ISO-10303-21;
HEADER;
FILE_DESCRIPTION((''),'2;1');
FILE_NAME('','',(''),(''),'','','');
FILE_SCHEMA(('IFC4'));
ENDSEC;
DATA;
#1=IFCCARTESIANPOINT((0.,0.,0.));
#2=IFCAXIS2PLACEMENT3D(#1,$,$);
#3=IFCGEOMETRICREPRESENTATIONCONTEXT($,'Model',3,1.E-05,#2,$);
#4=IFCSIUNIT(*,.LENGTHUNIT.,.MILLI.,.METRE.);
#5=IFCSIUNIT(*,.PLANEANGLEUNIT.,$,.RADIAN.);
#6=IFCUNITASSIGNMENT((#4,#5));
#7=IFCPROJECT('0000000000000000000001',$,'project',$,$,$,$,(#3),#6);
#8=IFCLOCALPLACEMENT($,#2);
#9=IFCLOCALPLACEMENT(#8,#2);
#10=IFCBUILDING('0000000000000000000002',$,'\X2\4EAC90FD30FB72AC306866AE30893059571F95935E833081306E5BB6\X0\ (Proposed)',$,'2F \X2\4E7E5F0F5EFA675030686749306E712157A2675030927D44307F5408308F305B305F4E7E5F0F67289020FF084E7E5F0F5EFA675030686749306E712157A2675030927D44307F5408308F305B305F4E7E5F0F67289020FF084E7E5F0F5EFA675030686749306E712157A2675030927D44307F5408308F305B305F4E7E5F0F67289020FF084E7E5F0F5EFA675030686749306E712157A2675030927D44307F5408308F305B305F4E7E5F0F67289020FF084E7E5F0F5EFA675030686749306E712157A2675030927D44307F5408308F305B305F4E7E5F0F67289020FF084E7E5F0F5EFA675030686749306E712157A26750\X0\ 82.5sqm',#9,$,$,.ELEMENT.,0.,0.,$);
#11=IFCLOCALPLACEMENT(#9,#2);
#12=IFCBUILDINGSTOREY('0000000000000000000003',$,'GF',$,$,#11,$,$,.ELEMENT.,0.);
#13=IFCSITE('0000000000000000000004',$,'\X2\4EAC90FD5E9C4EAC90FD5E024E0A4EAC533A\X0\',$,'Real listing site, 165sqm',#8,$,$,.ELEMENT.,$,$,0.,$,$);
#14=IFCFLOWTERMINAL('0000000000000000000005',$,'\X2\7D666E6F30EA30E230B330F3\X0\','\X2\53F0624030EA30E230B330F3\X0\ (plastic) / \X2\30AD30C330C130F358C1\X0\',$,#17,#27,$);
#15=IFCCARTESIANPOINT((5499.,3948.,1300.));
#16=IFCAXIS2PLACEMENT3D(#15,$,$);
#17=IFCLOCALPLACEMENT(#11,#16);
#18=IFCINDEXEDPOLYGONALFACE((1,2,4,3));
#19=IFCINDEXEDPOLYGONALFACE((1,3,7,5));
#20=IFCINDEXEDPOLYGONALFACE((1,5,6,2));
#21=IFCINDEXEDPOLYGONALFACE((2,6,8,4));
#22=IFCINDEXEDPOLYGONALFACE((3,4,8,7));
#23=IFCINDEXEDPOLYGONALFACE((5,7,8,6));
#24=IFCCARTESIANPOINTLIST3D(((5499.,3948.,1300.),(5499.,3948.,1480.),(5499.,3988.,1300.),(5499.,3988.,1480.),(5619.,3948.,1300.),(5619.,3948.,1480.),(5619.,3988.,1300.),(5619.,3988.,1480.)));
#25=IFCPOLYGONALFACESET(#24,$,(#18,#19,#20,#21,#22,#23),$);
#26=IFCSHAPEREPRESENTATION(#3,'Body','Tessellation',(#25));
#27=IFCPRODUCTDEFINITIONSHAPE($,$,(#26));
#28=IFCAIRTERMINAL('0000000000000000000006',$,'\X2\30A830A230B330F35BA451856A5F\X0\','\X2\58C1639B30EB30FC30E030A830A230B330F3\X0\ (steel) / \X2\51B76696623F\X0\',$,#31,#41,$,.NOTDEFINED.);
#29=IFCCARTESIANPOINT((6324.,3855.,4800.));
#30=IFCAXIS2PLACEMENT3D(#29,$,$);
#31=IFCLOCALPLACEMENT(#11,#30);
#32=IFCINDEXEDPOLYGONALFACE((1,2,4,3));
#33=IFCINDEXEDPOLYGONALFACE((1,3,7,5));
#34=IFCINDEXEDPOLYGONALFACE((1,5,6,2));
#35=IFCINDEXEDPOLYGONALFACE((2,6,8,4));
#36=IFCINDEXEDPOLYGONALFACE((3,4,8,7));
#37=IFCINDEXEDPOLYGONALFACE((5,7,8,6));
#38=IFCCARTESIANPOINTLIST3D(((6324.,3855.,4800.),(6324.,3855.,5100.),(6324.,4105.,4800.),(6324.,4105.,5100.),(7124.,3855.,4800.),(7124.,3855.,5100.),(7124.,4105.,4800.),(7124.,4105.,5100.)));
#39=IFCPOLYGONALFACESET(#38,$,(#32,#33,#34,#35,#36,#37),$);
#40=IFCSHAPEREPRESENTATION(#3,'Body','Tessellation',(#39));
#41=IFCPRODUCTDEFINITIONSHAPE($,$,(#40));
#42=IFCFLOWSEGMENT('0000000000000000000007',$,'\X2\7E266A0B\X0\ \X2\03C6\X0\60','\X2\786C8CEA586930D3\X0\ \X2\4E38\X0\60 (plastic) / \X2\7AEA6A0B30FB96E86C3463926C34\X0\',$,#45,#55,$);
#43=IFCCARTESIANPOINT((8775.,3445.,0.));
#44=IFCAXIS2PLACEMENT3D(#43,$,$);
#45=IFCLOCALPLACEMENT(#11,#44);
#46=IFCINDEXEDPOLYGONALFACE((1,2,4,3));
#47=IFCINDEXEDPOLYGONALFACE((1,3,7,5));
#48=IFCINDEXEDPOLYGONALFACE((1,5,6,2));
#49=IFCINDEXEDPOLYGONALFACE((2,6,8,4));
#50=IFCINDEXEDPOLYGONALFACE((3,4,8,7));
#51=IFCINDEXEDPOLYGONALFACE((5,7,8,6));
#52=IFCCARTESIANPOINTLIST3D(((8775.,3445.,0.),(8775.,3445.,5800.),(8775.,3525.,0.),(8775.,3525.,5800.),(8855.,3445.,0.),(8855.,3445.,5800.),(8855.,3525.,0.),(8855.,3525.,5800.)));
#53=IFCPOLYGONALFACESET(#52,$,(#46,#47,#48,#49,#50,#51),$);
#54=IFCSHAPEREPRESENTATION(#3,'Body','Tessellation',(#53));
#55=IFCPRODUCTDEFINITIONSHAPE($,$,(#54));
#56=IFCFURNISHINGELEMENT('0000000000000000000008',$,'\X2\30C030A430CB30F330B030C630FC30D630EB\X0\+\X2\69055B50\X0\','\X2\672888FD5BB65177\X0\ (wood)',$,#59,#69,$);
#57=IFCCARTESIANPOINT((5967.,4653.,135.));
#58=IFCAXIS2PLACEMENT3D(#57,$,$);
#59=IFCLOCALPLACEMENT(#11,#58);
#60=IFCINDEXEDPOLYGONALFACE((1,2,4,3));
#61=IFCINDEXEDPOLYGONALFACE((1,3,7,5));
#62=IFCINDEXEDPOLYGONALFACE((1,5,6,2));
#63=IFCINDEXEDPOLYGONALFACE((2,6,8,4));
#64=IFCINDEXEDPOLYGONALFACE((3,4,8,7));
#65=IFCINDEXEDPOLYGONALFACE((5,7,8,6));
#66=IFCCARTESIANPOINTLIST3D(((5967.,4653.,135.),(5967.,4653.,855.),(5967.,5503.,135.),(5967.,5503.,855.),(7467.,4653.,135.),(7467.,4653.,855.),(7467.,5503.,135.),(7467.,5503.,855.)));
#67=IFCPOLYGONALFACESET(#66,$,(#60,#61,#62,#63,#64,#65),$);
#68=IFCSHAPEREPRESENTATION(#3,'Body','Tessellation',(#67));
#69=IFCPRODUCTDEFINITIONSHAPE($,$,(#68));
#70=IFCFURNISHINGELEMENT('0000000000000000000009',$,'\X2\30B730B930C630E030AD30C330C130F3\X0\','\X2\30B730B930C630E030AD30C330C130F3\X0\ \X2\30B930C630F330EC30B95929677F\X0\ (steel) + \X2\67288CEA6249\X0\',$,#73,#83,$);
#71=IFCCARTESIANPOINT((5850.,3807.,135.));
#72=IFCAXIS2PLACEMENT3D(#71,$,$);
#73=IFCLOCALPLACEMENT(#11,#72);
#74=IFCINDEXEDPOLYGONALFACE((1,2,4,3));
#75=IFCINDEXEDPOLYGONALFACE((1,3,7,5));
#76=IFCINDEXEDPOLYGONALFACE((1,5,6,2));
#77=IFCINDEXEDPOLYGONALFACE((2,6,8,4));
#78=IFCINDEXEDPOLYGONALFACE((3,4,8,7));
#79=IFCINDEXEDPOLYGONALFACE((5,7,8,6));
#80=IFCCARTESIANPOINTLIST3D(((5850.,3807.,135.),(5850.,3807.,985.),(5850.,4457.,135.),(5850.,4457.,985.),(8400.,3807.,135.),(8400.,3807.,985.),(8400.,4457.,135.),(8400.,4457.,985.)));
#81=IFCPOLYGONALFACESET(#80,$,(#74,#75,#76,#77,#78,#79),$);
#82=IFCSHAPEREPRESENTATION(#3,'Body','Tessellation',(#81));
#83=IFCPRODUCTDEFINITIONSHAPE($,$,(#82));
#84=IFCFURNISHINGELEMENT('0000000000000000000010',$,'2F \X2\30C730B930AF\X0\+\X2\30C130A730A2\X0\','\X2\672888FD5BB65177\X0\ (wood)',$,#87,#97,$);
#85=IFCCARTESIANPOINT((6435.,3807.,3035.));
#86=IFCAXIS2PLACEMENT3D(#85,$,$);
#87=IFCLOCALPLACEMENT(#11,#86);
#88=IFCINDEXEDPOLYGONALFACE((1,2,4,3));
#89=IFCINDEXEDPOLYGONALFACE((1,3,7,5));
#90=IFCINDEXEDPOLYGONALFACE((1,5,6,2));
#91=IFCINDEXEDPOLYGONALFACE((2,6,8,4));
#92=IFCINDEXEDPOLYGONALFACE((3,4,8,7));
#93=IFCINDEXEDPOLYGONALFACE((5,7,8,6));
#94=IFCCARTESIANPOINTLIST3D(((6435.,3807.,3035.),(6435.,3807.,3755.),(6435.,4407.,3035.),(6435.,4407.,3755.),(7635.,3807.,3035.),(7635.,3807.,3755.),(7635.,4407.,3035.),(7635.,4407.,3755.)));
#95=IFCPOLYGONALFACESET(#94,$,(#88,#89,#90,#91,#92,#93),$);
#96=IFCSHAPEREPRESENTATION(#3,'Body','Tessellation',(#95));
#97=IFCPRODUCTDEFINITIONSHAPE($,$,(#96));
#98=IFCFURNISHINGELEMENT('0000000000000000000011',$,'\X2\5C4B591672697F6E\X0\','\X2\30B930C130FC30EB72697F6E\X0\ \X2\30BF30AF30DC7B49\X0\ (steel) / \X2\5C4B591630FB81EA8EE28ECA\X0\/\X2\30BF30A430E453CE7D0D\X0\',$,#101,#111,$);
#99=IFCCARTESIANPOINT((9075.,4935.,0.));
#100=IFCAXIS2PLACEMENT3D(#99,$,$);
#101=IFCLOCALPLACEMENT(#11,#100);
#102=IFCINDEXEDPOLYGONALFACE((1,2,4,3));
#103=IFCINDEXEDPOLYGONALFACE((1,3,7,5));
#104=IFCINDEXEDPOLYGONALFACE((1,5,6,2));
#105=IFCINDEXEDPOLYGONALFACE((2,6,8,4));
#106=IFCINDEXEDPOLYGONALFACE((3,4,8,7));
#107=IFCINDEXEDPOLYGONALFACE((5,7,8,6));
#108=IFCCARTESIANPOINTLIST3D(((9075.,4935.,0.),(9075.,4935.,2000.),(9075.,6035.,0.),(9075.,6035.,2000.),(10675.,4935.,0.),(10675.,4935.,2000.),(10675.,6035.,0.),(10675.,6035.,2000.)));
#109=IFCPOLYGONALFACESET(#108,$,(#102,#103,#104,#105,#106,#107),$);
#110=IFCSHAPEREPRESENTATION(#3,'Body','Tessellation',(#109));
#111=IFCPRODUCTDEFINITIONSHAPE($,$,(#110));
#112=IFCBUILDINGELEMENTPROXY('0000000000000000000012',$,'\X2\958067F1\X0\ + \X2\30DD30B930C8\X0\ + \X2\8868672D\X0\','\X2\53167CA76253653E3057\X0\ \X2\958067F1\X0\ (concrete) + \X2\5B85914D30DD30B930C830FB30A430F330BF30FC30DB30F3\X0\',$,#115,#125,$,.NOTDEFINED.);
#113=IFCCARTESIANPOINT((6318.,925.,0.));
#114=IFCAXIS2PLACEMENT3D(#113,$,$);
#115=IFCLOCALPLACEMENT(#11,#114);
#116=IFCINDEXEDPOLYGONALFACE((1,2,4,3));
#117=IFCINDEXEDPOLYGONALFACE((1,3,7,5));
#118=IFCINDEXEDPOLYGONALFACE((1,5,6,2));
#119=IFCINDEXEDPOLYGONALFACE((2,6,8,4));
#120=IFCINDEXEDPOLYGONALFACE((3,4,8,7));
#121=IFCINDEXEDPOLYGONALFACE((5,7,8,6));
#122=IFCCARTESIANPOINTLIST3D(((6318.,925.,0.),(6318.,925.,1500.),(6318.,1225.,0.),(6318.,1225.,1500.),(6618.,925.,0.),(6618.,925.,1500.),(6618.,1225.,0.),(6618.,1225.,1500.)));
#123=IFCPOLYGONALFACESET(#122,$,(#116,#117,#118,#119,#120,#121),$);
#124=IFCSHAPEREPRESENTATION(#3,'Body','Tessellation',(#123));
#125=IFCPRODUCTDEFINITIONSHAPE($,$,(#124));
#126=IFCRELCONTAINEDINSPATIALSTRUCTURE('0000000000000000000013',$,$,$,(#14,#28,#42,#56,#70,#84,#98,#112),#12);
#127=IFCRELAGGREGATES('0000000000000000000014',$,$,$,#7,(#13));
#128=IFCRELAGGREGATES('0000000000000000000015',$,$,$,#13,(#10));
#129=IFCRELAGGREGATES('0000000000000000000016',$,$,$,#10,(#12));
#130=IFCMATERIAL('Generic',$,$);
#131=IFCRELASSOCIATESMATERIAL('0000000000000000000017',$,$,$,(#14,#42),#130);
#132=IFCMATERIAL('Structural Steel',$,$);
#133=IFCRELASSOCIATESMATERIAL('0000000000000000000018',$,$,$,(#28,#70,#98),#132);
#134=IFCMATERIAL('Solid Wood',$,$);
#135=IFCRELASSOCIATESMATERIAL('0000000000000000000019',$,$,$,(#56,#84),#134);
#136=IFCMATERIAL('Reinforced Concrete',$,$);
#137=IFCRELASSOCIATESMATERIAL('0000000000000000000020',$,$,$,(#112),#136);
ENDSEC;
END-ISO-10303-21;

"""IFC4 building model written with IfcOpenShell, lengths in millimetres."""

from ifc_helpers import new_model, si_unit, frame, frame_2d, origin, place, context, project, spatial, rectangle, extrude, material, element, save


model = new_model("IFC4")

# Units and contexts
model_context = context("Model", 3, precision=1e-05, world=origin())
ifc_project = project(units=[si_unit("LENGTHUNIT", "METRE", prefix="MILLI"), si_unit("PLANEANGLEUNIT", "RADIAN")], contexts=[model_context])

# Site, building, storey
site_placement = place(None, origin())
site = spatial("IfcSite", under=ifc_project, at=site_placement, Name="京都府京都市上京区", ObjectType="Real listing site, 165sqm", CompositionType="ELEMENT", RefElevation=0.0)
building_placement = place(site_placement, origin())
building = spatial("IfcBuilding", under=site, at=building_placement, Name="京都・犬と暮らす土間広めの家 (Proposed)", ObjectType="2F 乾式建材と杉の無垢材を組み合わせた乾式木造（乾式建材と杉の無垢材を組み合わせた乾式木造（乾式建材と杉の無垢材を組み合わせた乾式木造（乾式建材と杉の無垢材を組み合わせた乾式木造（乾式建材と杉の無垢材を組み合わせた乾式木造（乾式建材と杉の無垢材 82.5sqm", CompositionType="ELEMENT", ElevationOfRefHeight=0.0, ElevationOfTerrain=0.0)
storey_placement = place(building_placement, origin())
storey = spatial("IfcBuildingStorey", under=building, at=storey_placement, Name="GF", CompositionType="ELEMENT", Elevation=0.0)

# Shared definitions
ifc_material_1 = material(Name="Solid Wood")

# Shared definitions
ifc_material_2 = material(Name="Reinforced Concrete")

# Shared definitions
ifc_material_3 = material(Name="Structural Steel")

# Flow terminal
ifc_material_4 = material(Name="Generic")
flow_terminal_1_placement = place(storey_placement, frame((5499.0, 3948.0, 1300.0)))
element("IfcFlowTerminal", 1, at=flow_terminal_1_placement, inside=storey, material=ifc_material_4, Name="給湯リモコン", Description="台所リモコン (plastic) / キッチン壁", context=model_context, shape_type="SweptSolid", body=[
    extrude(rectangle(XDim=120.0, YDim=40.0, at=frame_2d((60.0, 20.0))), frame((5499.0, 3948.0, 1300.0)), (0.0, 0.0, 1.0), 180.0),
])

# Air terminal
air_terminal_placement = place(storey_placement, frame((6324.0, 3855.0, 4800.0)))
element("IfcAirTerminal", 2, at=air_terminal_placement, inside=storey, material=ifc_material_3, Name="エアコン室内機", Description="壁掛ルームエアコン (steel) / 冷暖房", PredefinedType="NOTDEFINED", context=model_context, shape_type="SweptSolid", body=[
    extrude(rectangle(XDim=800.0, YDim=250.0, at=frame_2d((400.0, 125.0))), frame((6324.0, 3855.0, 4800.0)), (0.0, 0.0, 1.0), 300.0),
])

# Flow segment
flow_segment_placement = place(storey_placement, frame((8775.0, 3445.0, 0.0)))
element("IfcFlowSegment", 3, at=flow_segment_placement, inside=storey, material=ifc_material_4, Name="縦樋 φ60", Description="硬質塩ビ 丸60 (plastic) / 竪樋・雨水排水", context=model_context, shape_type="SweptSolid", body=[
    extrude(rectangle(XDim=80.0, YDim=80.0, at=frame_2d((40.0, 40.0))), frame((8775.0, 3445.0, 0.0)), (0.0, 0.0, 1.0), 5800.0),
])

# Furnishing elements
furnishing_1_placement = place(storey_placement, frame((5967.0, 4653.0, 135.0)))
element("IfcFurnishingElement", 4, at=furnishing_1_placement, inside=storey, material=ifc_material_1, Name="ダイニングテーブル+椅子", Description="木製家具 (wood)", context=model_context, shape_type="SweptSolid", body=[
    extrude(rectangle(XDim=1500.0, YDim=850.0, at=frame_2d((750.0, 425.0))), frame((5967.0, 4653.0, 135.0)), (0.0, 0.0, 1.0), 720.0),
])
furnishing_2_placement = place(storey_placement, frame((5850.0, 3807.0, 135.0)))
element("IfcFurnishingElement", 5, at=furnishing_2_placement, inside=storey, material=ifc_material_3, Name="システムキッチン", Description="システムキッチン ステンレス天板 (steel) + 木質扉", context=model_context, shape_type="SweptSolid", body=[
    extrude(rectangle(XDim=2550.0, YDim=650.0, at=frame_2d((1275.0, 325.0))), frame((5850.0, 3807.0, 135.0)), (0.0, 0.0, 1.0), 850.0),
])
furnishing_3_placement = place(storey_placement, frame((6435.0, 3807.0, 3035.0)))
element("IfcFurnishingElement", 6, at=furnishing_3_placement, inside=storey, material=ifc_material_1, Name="2F デスク+チェア", Description="木製家具 (wood)", context=model_context, shape_type="SweptSolid", body=[
    extrude(rectangle(XDim=1200.0, YDim=600.0, at=frame_2d((600.0, 300.0))), frame((6435.0, 3807.0, 3035.0)), (0.0, 0.0, 1.0), 720.0),
])
furnishing_4_placement = place(storey_placement, frame((9075.0, 4935.0, 0.0)))
element("IfcFurnishingElement", 7, at=furnishing_4_placement, inside=storey, material=ifc_material_3, Name="屋外物置", Description="スチール物置 タクボ等 (steel) / 屋外・自転車/タイヤ収納", context=model_context, shape_type="SweptSolid", body=[
    extrude(rectangle(XDim=1600.0, YDim=1100.0, at=frame_2d((800.0, 550.0))), frame((9075.0, 4935.0, 0.0)), (0.0, 0.0, 1.0), 2000.0),
])

# Building element proxy
proxy_placement = place(storey_placement, frame((6318.0, 925.0, 0.0)))
element("IfcBuildingElementProxy", 8, at=proxy_placement, inside=storey, material=ifc_material_2, Name="門柱 + ポスト + 表札", Description="化粧打放し 門柱 (concrete) + 宅配ポスト・インターホン", PredefinedType="NOTDEFINED", context=model_context, shape_type="SweptSolid", body=[
    extrude(rectangle(XDim=300.0, YDim=300.0, at=frame_2d((150.0, 150.0))), frame((6318.0, 925.0, 0.0)), (0.0, 0.0, 1.0), 1500.0),
])

save(model, "model.ifc")
